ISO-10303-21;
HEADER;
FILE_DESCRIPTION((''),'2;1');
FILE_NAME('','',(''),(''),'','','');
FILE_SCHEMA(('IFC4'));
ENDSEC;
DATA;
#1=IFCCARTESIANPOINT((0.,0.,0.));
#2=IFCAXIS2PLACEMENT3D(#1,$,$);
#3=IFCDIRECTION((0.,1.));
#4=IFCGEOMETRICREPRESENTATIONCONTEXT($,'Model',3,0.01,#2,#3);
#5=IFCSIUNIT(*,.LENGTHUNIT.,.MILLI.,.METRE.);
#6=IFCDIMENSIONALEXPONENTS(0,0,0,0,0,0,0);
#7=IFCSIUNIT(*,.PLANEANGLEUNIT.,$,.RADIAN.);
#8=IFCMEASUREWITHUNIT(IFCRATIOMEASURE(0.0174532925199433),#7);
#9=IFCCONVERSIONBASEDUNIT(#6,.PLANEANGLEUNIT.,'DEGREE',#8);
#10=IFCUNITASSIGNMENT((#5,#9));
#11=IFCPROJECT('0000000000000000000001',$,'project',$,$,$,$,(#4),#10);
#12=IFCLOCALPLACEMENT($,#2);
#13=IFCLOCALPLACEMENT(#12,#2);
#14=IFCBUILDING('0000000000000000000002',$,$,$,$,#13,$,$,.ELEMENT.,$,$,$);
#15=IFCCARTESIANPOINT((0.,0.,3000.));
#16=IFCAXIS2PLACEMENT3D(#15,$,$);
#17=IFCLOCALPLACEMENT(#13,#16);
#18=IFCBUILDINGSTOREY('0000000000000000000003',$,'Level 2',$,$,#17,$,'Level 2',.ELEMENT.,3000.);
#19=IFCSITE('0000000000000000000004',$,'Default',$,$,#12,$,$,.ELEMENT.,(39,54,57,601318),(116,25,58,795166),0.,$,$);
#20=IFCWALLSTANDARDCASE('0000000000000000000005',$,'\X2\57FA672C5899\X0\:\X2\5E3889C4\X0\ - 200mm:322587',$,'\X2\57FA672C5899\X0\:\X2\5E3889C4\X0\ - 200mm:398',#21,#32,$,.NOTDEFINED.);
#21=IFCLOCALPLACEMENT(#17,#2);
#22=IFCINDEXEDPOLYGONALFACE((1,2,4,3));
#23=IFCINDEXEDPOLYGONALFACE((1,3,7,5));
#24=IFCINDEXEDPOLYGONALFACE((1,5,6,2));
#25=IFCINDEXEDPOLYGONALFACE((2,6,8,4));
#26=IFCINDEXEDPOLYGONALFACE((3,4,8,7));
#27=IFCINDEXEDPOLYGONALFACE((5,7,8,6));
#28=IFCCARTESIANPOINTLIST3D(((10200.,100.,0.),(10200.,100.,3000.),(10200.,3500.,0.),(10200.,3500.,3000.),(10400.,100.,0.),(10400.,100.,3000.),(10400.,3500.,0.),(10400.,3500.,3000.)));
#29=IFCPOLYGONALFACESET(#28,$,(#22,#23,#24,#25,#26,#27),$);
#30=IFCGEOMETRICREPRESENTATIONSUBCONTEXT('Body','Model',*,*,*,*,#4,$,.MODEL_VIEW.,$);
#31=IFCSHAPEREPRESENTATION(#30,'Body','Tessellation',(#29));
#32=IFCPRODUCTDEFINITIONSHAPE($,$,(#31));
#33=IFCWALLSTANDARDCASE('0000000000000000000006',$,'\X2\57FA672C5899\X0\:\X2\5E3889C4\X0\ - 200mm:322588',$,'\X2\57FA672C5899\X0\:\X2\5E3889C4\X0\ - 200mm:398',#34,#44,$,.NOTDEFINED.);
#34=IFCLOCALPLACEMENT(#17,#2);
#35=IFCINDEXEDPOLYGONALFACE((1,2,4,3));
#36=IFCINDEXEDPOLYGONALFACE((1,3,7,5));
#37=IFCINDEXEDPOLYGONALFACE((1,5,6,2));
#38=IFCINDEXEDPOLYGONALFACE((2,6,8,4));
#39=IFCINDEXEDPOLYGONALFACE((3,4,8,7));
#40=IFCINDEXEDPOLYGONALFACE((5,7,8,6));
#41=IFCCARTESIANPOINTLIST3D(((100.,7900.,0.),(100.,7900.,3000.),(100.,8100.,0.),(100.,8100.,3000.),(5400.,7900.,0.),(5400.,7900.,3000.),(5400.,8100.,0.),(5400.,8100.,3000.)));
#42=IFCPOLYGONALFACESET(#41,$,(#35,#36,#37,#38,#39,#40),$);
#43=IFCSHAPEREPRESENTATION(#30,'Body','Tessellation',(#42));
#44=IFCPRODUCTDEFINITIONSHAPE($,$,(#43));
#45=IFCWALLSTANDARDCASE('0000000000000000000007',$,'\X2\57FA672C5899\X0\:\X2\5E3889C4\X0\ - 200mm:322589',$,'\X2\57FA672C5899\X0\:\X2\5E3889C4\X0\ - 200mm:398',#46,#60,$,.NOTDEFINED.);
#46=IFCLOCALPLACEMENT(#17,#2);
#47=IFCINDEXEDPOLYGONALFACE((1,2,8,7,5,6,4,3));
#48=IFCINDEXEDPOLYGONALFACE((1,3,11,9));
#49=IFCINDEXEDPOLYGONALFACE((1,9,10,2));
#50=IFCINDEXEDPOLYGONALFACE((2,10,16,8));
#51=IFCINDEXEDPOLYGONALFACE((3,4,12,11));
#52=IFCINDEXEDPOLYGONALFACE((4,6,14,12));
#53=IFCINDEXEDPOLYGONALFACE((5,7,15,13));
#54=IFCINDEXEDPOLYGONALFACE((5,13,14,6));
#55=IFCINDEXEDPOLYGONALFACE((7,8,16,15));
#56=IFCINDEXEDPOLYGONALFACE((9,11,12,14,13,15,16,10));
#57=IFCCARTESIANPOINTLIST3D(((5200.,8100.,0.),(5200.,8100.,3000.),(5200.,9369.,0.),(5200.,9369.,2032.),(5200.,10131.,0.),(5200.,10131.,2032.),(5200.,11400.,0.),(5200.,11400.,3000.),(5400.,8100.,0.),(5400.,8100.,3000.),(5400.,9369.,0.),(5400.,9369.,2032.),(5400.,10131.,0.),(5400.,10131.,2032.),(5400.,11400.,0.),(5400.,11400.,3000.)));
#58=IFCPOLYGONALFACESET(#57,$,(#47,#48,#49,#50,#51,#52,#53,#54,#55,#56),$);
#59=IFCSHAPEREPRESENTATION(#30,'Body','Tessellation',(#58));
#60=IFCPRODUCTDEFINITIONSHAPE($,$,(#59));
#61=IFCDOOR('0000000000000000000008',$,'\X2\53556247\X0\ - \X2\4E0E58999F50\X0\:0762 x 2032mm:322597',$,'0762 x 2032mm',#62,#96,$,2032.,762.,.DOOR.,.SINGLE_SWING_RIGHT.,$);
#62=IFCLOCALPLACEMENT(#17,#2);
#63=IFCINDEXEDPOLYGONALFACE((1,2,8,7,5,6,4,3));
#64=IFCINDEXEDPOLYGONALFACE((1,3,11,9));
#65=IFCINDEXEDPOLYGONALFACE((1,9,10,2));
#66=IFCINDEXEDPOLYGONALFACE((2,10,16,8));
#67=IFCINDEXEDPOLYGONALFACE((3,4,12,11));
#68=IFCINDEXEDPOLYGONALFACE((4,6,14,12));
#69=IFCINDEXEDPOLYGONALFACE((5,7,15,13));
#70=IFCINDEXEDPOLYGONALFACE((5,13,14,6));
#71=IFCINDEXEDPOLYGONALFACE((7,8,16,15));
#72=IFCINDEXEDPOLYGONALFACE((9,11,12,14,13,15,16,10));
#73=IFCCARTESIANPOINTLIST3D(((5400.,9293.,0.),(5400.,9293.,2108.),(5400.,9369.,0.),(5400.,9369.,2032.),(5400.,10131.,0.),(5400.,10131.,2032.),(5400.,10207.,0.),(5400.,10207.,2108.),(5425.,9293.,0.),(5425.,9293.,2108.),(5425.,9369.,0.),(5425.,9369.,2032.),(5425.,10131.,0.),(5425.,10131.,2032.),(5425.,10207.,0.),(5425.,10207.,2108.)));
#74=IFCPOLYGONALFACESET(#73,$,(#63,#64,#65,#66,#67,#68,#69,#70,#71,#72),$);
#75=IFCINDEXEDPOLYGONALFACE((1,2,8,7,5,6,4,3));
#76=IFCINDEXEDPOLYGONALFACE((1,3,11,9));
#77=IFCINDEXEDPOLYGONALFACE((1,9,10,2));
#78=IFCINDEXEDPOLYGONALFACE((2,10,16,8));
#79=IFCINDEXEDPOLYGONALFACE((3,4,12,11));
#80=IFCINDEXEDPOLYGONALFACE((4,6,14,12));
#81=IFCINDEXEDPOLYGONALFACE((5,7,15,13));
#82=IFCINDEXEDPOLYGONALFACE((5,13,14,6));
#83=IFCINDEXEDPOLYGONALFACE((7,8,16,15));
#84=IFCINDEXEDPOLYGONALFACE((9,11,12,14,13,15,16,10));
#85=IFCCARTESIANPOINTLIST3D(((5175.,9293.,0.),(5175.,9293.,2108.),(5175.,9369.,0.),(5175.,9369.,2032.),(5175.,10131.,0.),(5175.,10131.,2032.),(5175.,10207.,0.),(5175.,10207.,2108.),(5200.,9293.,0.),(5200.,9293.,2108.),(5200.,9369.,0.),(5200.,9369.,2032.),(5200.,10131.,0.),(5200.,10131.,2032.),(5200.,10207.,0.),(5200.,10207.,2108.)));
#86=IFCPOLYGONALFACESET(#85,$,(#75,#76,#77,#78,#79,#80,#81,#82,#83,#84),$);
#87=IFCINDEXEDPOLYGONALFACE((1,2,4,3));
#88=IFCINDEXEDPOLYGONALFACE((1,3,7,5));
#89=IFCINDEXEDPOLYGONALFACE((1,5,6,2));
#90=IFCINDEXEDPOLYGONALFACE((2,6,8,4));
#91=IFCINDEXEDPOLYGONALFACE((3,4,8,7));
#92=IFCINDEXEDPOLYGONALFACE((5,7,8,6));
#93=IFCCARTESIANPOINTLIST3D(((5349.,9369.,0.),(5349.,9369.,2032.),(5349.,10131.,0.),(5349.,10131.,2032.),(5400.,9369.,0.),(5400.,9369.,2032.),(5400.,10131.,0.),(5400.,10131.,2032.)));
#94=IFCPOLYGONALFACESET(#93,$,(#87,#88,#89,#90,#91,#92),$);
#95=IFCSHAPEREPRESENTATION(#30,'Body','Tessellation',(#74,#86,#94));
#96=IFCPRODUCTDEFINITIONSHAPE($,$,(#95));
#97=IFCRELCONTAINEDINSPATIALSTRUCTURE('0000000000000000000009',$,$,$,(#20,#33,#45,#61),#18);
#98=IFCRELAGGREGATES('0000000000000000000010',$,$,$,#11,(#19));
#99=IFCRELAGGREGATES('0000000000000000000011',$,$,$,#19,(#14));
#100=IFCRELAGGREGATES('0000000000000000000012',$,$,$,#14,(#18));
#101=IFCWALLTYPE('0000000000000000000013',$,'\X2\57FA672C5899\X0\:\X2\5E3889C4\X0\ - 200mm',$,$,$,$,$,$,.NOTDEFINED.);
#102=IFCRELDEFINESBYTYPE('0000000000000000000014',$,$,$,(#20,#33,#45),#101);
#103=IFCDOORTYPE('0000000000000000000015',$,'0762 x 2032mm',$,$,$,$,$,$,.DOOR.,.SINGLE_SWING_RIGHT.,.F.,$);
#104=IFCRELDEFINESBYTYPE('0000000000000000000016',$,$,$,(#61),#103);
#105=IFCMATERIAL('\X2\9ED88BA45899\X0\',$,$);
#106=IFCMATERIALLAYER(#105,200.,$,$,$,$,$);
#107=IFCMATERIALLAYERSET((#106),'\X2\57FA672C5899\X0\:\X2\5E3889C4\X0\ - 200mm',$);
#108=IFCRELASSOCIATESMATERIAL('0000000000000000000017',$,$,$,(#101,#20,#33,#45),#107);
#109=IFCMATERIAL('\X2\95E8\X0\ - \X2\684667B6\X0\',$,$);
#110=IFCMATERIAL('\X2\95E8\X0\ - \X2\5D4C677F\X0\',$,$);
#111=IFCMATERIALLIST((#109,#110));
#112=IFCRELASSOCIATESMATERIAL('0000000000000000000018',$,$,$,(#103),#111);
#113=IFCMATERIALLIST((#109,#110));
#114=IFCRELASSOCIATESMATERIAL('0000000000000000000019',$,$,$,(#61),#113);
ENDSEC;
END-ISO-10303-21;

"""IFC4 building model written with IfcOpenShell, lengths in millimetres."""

from ifc_helpers import new_model, entity, si_unit, converted_unit, direction, frame, frame_2d, origin, place, context, subcontext, project, spatial, polyline, rectangle, outline, extrude, source, transform, mapped, material, material_list, layer, layer_set, layer_usage, type_object, type_shapes, element, fill, save


model = new_model("IFC4")

# Units and contexts
model_context = context("Model", 3, precision=0.01, world=origin(), true_north=direction((0.0, 1.0)))
body_context = subcontext(model_context, "Body", "Model", "MODEL_VIEW")
ifc_project = project(units=[si_unit("LENGTHUNIT", "METRE", prefix="MILLI"), converted_unit("PLANEANGLEUNIT", "DEGREE", entity("IfcRatioMeasure", 0.0174532925199433), si_unit("PLANEANGLEUNIT", "RADIAN"), dimensions=[0, 0, 0, 0, 0, 0, 0])], contexts=[model_context])

# Site, building, storey
site_placement = place(None, origin())
site = spatial("IfcSite", under=ifc_project, at=site_placement, Name="Default", CompositionType="ELEMENT", RefLatitude=(39, 54, 57, 601318), RefLongitude=(116, 25, 58, 795166), RefElevation=0.0)
building_placement = place(site_placement, origin())
building = spatial("IfcBuilding", under=site, at=building_placement, CompositionType="ELEMENT")
storey_placement = place(building_placement, frame((0.0, 0.0, 3000.0)))
storey = spatial("IfcBuildingStorey", under=building, at=storey_placement, Name="Level 2", LongName="Level 2", CompositionType="ELEMENT", Elevation=3000.0)

# Shared definitions
ifc_material_1 = material(Name="默认墙")
ifc_layer_1 = layer(ifc_material_1, 200.0)
ifc_layer_set_1 = layer_set([ifc_layer_1], Name="基本墙:常规 - 200mm")
wall_type = type_object("IfcWallType", Name="基本墙:常规 - 200mm", PredefinedType="NOTDEFINED", material=ifc_layer_set_1)

# Shared definitions
ifc_material_2 = material(Name="门 - 框架")
ifc_material_3 = material(Name="门 - 嵌板")
ifc_material_list_1 = material_list([ifc_material_2, ifc_material_3])
door_type_1 = type_object("IfcDoorType", Name="0762 x 2032mm", OperationType="SINGLE_SWING_RIGHT", ParameterTakesPrecedence=False, PredefinedType="DOOR", material=ifc_material_list_1)
shared_shape_1 = source(origin(), body_context, "Body", "SweptSolid", [
    extrude(outline(polyline([(-457.0, -1073.0), (457.0, -1073.0), (457.0, 1035.0), (381.0, 1035.0), (381.0, -997.0), (-381.0, -997.0), (-381.0, 1035.0), (-457.0, 1035.0), (-457.0, -1073.0)])), frame((381.0, 200.0, 1035.0), z_axis=(0.0, 1.0, 0.0), x_axis=(1.0, 0.0, 0.0)), (0.0, 0.0, 1.0), 25.0),
    extrude(outline(polyline([(-1073.0, -457.0), (1035.0, -457.0), (1035.0, -381.0), (-997.0, -381.0), (-997.0, 381.0), (1035.0, 381.0), (1035.0, 457.0), (-1073.0, 457.0), (-1073.0, -457.0)])), frame((381.0, -25.0, 1035.0), z_axis=(0.0, 1.0, 0.0), x_axis=(0.0, 0.0, -1.0)), (0.0, 0.0, 1.0), 25.0),
    extrude(rectangle(XDim=51.0, YDim=762.0, at=frame_2d((0.0, 0.0), x_axis=(1.0, 0.0))), frame((381.0, 174.5, 0.0), z_axis=(0.0, 0.0, 1.0), x_axis=(0.0, 1.0, 0.0)), (0.0, 0.0, 1.0), 2032.0),
])
type_shapes(door_type_1, [shared_shape_1])

# Walls
ifc_layer_usage_1 = layer_usage(ifc_layer_set_1, "AXIS2", "NEGATIVE", 100.0)
wall_1_placement = place(storey_placement, frame((10300.0, 3500.0, 0.0), z_axis=(0.0, 0.0, 1.0), x_axis=(0.0, -1.0, 0.0)))
element("IfcWallStandardCase", 1, at=wall_1_placement, inside=storey, type_object=wall_type, material=ifc_layer_usage_1, Name="基本墙:常规 - 200mm:322587", ObjectType="基本墙:常规 - 200mm:398", PredefinedType="NOTDEFINED", context=body_context, shape_type="SweptSolid", body=[
    extrude(rectangle(XDim=3400.0, YDim=200.0, at=frame_2d((1700.0, 0.0), x_axis=(-1.0, 0.0))), origin(), (0.0, 0.0, 1.0), 3000.0),
])
ifc_layer_usage_2 = layer_usage(ifc_layer_set_1, "AXIS2", "NEGATIVE", 100.0)
wall_2_placement = place(storey_placement, frame((100.0, 8000.0, 0.0)))
element("IfcWallStandardCase", 2, at=wall_2_placement, inside=storey, type_object=wall_type, material=ifc_layer_usage_2, Name="基本墙:常规 - 200mm:322588", ObjectType="基本墙:常规 - 200mm:398", PredefinedType="NOTDEFINED", context=body_context, shape_type="SweptSolid", body=[
    extrude(rectangle(XDim=5300.0, YDim=200.0, at=frame_2d((2650.0, 0.0), x_axis=(-1.0, 0.0))), origin(), (0.0, 0.0, 1.0), 3000.0),
])

# Wall, opening, door
ifc_layer_usage_3 = layer_usage(ifc_layer_set_1, "AXIS2", "NEGATIVE", 100.0)
wall_3_placement = place(storey_placement, frame((5300.0, 8100.0, 0.0), z_axis=(0.0, 0.0, 1.0), x_axis=(0.0, 1.0, 0.0)))
wall_3 = element("IfcWallStandardCase", 3, at=wall_3_placement, inside=storey, type_object=wall_type, material=ifc_layer_usage_3, Name="基本墙:常规 - 200mm:322589", ObjectType="基本墙:常规 - 200mm:398", PredefinedType="NOTDEFINED", context=body_context, shape_type="SweptSolid", body=[
    extrude(rectangle(XDim=3300.0, YDim=200.0, at=frame_2d((1650.0, 0.0), x_axis=(-1.0, 0.0))), origin(), (0.0, 0.0, 1.0), 3000.0),
])
opening_1_placement = place(wall_3_placement, frame((2031.0, 100.0, 0.0)))
opening_1 = element("IfcOpeningElement", 4, at=opening_1_placement, cuts=wall_3, ObjectType="Opening", PredefinedType="OPENING", context=body_context, shape_type="SweptSolid", body=[
    extrude(rectangle(XDim=762.0, YDim=2032.0, at=frame_2d((1016.0, 381.0), x_axis=(0.0, 1.0))), frame((0.0, 0.0, 0.0), z_axis=(0.0, -1.0, 0.0), x_axis=(0.0, 0.0, 1.0)), (0.0, 0.0, 1.0), 200.0),
])
ifc_material_list_2 = material_list([ifc_material_2, ifc_material_3])
door_1_placement = place(opening_1_placement, frame((0.0, 0.0, 0.0), z_axis=(0.0, 0.0, 1.0), x_axis=(-1.0, 0.0, 0.0)))
door_1 = element("IfcDoor", 5, at=door_1_placement, inside=storey, type_object=door_type_1, material=ifc_material_list_2, Name="单扇 - 与墙齐:0762 x 2032mm:322597", ObjectType="0762 x 2032mm", OperationType="SINGLE_SWING_RIGHT", OverallHeight=2032.0, OverallWidth=762.0, PredefinedType="DOOR", context=body_context, shape_type="MappedRepresentation", body=[
    mapped(shared_shape_1, transform((0.0, 0.0, 0.0), scale=1.0)),
])
fill(opening_1, door_1)

save(model, "model.ifc")
